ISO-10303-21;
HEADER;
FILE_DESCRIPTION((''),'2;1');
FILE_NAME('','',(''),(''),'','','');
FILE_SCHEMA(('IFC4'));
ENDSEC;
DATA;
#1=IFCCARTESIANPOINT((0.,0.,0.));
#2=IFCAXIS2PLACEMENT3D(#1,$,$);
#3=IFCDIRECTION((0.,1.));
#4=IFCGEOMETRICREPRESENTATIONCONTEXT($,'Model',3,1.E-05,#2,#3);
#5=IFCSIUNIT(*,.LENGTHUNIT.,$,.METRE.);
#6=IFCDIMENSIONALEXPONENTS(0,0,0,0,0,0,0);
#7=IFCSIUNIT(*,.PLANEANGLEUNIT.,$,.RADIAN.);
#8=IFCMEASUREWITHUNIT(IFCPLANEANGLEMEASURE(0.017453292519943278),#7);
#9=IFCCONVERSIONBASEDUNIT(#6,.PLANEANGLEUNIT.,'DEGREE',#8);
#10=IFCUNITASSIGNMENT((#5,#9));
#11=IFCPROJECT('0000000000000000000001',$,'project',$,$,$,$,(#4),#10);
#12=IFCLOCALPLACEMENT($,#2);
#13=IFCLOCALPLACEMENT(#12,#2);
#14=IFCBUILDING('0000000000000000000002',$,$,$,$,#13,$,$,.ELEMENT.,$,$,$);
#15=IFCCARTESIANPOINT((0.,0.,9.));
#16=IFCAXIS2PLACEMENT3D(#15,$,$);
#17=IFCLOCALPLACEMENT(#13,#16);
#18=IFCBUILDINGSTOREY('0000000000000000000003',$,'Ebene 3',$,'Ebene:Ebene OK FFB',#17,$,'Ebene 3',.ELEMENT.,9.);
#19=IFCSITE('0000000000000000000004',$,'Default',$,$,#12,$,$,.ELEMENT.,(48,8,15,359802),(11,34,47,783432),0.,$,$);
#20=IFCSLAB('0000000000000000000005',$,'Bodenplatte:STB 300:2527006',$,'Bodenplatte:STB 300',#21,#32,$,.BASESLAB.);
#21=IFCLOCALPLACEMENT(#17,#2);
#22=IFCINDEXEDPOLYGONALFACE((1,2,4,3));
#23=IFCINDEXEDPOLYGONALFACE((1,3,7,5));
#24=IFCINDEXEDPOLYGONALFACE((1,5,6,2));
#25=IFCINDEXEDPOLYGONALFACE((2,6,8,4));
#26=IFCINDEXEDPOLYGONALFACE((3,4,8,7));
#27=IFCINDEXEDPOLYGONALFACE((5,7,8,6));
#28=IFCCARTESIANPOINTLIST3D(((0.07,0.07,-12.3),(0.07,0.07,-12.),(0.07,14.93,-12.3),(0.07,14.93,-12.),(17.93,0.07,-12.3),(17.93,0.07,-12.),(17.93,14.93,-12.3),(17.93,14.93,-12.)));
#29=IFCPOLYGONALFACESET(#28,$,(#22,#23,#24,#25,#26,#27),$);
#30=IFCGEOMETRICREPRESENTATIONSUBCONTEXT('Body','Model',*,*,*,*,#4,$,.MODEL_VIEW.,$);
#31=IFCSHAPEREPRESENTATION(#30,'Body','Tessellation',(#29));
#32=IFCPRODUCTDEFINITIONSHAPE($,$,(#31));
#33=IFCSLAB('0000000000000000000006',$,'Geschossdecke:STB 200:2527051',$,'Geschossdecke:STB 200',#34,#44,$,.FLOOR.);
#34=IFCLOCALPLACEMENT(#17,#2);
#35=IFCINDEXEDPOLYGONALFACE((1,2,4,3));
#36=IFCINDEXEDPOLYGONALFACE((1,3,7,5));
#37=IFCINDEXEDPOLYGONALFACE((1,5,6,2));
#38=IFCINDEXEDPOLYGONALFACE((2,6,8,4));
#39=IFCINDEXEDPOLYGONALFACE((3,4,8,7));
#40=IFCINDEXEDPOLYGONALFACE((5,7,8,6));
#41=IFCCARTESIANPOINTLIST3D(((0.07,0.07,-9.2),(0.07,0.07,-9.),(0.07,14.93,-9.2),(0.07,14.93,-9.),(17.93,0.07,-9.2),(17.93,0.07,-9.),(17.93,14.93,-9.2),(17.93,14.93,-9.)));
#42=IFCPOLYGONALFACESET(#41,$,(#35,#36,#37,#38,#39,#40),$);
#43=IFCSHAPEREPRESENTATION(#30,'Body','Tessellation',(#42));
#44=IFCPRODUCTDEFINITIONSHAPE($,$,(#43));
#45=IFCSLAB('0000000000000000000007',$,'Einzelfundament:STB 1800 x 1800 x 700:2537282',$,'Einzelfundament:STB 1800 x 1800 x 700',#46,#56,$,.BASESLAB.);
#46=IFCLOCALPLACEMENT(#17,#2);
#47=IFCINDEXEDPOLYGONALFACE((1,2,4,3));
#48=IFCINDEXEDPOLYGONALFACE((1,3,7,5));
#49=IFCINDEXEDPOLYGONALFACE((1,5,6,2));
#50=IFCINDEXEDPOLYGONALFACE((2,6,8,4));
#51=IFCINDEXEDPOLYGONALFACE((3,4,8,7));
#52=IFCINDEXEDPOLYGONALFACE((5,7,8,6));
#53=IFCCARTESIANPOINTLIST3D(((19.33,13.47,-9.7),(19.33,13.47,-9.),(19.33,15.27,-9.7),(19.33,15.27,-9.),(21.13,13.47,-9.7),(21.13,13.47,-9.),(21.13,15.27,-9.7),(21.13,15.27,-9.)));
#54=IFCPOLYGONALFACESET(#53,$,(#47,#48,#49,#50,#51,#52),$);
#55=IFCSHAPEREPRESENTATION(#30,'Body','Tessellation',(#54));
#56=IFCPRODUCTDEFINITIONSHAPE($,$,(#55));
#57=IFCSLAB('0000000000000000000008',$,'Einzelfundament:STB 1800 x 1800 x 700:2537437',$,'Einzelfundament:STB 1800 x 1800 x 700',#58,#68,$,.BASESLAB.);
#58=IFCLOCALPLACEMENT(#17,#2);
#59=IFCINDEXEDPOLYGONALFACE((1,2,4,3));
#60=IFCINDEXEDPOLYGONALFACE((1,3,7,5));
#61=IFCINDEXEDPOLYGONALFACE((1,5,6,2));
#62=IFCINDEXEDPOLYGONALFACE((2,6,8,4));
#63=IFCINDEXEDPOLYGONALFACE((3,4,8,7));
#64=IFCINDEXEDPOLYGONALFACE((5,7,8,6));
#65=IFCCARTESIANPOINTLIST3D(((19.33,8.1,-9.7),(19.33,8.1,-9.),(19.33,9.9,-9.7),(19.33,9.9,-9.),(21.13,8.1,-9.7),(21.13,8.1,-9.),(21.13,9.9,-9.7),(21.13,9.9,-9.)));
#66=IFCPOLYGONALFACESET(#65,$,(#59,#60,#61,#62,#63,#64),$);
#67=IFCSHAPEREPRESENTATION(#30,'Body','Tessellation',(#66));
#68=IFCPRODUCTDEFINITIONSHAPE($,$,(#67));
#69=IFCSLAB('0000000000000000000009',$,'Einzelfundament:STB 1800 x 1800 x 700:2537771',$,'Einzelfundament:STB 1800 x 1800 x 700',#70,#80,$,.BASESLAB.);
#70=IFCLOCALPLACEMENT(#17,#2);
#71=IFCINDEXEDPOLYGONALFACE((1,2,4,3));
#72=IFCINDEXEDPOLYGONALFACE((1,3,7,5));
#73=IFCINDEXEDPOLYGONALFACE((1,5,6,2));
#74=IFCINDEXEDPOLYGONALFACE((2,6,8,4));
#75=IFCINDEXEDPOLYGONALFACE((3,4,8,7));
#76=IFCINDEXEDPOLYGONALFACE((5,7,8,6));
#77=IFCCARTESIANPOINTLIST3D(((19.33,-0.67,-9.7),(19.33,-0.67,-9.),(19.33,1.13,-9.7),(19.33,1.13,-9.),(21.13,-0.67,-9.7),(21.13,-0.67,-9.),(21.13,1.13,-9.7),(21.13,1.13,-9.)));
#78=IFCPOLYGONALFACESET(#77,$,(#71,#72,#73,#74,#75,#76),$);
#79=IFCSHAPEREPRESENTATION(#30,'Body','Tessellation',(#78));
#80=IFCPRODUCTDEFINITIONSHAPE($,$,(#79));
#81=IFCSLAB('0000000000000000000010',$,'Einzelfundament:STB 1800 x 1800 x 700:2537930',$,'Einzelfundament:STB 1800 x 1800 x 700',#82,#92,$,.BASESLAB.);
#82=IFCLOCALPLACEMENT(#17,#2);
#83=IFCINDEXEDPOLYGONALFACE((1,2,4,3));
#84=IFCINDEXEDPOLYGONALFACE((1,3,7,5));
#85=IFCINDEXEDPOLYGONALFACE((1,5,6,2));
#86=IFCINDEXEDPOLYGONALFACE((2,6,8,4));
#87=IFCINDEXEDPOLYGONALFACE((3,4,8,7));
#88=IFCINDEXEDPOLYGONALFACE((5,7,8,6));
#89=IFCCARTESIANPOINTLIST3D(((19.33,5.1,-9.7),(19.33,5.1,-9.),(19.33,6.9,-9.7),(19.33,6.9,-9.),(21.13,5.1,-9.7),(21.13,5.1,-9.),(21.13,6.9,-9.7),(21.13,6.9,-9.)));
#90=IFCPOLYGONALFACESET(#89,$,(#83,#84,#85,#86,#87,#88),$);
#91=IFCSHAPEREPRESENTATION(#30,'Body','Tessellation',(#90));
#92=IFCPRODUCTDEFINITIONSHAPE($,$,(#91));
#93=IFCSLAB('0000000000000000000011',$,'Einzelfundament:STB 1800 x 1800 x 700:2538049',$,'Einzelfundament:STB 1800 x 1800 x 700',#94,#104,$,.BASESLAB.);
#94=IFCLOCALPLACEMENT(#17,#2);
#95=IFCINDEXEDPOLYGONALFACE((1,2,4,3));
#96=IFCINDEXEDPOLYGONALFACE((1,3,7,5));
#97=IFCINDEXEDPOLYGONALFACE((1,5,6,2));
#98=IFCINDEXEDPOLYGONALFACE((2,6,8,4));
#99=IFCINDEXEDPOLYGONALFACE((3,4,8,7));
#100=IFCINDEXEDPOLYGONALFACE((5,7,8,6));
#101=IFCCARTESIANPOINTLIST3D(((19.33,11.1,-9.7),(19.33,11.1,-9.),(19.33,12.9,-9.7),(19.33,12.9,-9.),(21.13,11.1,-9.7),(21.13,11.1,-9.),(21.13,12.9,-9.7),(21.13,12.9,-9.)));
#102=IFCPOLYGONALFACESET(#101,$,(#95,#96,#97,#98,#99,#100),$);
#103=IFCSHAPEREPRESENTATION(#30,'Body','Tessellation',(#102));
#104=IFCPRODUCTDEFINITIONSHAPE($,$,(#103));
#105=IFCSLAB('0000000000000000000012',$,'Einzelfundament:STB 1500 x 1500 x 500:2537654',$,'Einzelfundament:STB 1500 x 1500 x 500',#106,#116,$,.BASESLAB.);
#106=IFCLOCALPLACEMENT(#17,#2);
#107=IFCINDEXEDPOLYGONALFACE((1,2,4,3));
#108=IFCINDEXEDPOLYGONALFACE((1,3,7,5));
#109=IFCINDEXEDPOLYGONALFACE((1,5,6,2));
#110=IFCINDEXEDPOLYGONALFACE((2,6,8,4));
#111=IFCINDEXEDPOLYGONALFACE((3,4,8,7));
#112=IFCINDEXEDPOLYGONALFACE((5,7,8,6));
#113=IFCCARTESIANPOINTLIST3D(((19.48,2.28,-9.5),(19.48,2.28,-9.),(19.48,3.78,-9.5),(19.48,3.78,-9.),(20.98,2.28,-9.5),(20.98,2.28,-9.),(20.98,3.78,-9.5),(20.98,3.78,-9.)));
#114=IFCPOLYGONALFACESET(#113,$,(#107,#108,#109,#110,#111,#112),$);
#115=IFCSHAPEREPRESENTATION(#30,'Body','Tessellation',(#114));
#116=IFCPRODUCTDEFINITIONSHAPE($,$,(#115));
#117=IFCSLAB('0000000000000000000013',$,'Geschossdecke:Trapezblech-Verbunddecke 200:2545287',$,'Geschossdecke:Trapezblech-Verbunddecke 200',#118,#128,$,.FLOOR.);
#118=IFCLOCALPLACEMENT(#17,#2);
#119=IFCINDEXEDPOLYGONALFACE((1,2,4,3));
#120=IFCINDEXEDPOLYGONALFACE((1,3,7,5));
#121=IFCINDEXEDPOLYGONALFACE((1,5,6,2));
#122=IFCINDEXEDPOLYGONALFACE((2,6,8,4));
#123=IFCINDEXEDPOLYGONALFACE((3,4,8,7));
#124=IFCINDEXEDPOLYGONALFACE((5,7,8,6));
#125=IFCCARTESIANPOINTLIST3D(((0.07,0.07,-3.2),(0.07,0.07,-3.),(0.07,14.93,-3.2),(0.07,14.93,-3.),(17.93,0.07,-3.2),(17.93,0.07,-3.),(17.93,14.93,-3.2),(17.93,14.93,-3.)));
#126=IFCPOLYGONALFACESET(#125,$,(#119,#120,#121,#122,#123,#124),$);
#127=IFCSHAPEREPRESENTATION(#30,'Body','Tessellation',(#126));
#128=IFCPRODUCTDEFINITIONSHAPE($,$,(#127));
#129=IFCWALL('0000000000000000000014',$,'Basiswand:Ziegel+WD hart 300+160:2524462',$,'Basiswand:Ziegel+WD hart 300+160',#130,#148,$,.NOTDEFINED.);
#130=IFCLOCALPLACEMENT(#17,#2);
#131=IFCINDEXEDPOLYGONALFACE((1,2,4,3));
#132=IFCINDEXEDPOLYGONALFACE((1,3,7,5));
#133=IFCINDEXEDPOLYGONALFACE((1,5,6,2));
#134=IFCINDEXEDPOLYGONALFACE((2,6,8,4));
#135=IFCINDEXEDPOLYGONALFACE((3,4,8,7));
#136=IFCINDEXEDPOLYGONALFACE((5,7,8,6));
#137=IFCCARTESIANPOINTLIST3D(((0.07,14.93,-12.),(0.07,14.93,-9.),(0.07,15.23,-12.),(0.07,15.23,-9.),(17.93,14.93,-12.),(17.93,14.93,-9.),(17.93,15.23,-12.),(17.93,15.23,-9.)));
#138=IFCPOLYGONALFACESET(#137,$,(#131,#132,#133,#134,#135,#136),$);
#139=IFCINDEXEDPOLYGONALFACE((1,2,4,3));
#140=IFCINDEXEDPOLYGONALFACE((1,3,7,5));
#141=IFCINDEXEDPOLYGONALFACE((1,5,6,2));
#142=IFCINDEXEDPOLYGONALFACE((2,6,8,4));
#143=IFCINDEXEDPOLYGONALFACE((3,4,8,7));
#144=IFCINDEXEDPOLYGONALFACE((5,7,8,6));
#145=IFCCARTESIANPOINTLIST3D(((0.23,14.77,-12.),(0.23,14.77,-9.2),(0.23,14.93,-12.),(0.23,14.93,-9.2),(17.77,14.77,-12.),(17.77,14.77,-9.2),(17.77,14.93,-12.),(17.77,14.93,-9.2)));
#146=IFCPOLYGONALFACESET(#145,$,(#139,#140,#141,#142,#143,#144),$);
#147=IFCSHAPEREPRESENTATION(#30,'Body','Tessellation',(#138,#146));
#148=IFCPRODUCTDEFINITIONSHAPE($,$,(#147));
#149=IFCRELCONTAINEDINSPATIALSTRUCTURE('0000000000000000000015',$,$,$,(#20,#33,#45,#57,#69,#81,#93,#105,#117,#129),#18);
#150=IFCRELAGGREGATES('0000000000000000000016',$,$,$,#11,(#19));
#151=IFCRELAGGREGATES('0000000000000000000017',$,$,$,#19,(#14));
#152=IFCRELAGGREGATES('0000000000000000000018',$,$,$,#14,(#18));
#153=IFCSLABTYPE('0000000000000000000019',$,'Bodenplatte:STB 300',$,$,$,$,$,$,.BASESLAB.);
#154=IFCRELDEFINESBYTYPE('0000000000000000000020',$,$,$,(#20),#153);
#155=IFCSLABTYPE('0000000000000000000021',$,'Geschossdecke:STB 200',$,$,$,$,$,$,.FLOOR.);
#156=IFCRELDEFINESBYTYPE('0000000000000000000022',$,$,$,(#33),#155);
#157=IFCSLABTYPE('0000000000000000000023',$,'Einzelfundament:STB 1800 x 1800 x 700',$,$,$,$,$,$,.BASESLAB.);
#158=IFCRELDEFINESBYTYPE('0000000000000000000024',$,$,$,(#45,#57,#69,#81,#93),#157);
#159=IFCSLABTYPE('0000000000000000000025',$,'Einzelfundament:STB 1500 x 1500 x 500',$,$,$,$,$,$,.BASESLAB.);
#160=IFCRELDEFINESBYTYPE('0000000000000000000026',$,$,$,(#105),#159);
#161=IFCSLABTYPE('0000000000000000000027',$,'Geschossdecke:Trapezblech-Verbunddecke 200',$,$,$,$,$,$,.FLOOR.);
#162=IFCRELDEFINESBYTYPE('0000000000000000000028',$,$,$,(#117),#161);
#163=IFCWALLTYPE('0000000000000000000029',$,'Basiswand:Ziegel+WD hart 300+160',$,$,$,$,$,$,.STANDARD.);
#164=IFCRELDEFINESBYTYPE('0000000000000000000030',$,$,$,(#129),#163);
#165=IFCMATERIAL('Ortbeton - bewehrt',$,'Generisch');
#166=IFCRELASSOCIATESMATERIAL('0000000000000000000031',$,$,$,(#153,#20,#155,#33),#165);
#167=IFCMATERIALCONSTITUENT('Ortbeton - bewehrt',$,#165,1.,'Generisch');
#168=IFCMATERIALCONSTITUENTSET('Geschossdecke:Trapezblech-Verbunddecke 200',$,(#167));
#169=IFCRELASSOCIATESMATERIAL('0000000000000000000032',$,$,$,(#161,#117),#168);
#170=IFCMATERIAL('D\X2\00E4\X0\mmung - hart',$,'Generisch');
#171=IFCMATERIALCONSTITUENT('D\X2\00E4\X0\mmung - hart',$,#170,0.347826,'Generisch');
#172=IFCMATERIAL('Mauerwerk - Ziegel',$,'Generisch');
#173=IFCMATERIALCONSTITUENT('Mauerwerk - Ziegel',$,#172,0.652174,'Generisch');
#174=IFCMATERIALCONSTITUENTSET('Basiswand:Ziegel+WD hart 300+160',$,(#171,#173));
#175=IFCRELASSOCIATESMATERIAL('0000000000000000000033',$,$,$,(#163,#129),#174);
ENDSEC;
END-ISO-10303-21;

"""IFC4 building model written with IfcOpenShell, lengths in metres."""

from ifc_helpers import new_model, entity, si_unit, converted_unit, direction, frame, origin, place, context, subcontext, project, spatial, indexed_curve, outline, extrude, material, constituent, constituent_set, type_object, element, save


model = new_model("IFC4")

# Units and contexts
model_context = context("Model", 3, precision=1e-05, world=origin(), true_north=direction((0.0, 1.0)))
body_context = subcontext(model_context, "Body", "Model", "MODEL_VIEW")
ifc_project = project(units=[si_unit("LENGTHUNIT", "METRE"), converted_unit("PLANEANGLEUNIT", "DEGREE", entity("IfcPlaneAngleMeasure", 0.017453292519943278), si_unit("PLANEANGLEUNIT", "RADIAN"), dimensions=[0, 0, 0, 0, 0, 0, 0])], contexts=[model_context])

# Site, building, storey
site_placement = place(None, origin())
site = spatial("IfcSite", under=ifc_project, at=site_placement, Name="Default", CompositionType="ELEMENT", RefLatitude=(48, 8, 15, 359802), RefLongitude=(11, 34, 47, 783432), RefElevation=0.0)
building_placement = place(site_placement, origin())
building = spatial("IfcBuilding", under=site, at=building_placement, CompositionType="ELEMENT")
storey_placement = place(building_placement, frame((0.0, 0.0, 9.0)))
storey = spatial("IfcBuildingStorey", under=building, at=storey_placement, Name="Ebene 3", ObjectType="Ebene:Ebene OK FFB", LongName="Ebene 3", CompositionType="ELEMENT", Elevation=9.0)

# Slabs
ifc_material_1 = material(Name="Ortbeton - bewehrt", Category="Generisch")
slab_type_1 = type_object("IfcSlabType", Name="Bodenplatte:STB 300", PredefinedType="BASESLAB", material=ifc_material_1)
slab_1_placement = place(storey_placement, origin())
element("IfcSlab", 1, at=slab_1_placement, inside=storey, type_object=slab_type_1, material=ifc_material_1, Name="Bodenplatte:STB 300:2527006", ObjectType="Bodenplatte:STB 300", PredefinedType="BASESLAB", context=body_context, shape_type="SweptSolid", body=[
    extrude(outline(indexed_curve([(-7.43, -8.93), (7.43, -8.93), (7.43, 8.93), (-7.43, 8.93), (-7.43, -8.93)], self_intersect=False)), frame((9.0, 7.5, -12.0), z_axis=(0.0, 0.0, -1.0), x_axis=(0.0, 1.0, 0.0)), (0.0, 0.0, 1.0), 0.3),
])
slab_type_2 = type_object("IfcSlabType", Name="Geschossdecke:STB 200", PredefinedType="FLOOR", material=ifc_material_1)
slab_2_placement = place(storey_placement, origin())
element("IfcSlab", 2, at=slab_2_placement, inside=storey, type_object=slab_type_2, material=ifc_material_1, Name="Geschossdecke:STB 200:2527051", ObjectType="Geschossdecke:STB 200", PredefinedType="FLOOR", context=body_context, shape_type="SweptSolid", body=[
    extrude(outline(indexed_curve([(-7.43, -8.93), (7.43, -8.93), (7.43, 8.93), (-7.43, 8.93), (-7.43, -8.93)], self_intersect=False)), frame((9.0, 7.5, -9.0), z_axis=(0.0, 0.0, -1.0), x_axis=(0.0, 1.0, 0.0)), (0.0, 0.0, 1.0), 0.2),
])

# Slabs
slab_type_3 = type_object("IfcSlabType", Name="Einzelfundament:STB 1800 x 1800 x 700", PredefinedType="BASESLAB")
slab_3_placement = place(storey_placement, origin())
element("IfcSlab", 3, at=slab_3_placement, inside=storey, type_object=slab_type_3, Name="Einzelfundament:STB 1800 x 1800 x 700:2537282", ObjectType="Einzelfundament:STB 1800 x 1800 x 700", PredefinedType="BASESLAB", context=body_context, shape_type="SweptSolid", body=[
    extrude(outline(indexed_curve([(-0.9, -0.9), (0.9, -0.9), (0.9, 0.9), (-0.9, 0.9), (-0.9, -0.9)], self_intersect=False)), frame((20.23, 14.37, -9.7), z_axis=(0.0, 0.0, 1.0), x_axis=(-1.0, 0.0, 0.0)), (0.0, 0.0, 1.0), 0.7),
])
slab_4_placement = place(storey_placement, origin())
element("IfcSlab", 4, at=slab_4_placement, inside=storey, type_object=slab_type_3, Name="Einzelfundament:STB 1800 x 1800 x 700:2537437", ObjectType="Einzelfundament:STB 1800 x 1800 x 700", PredefinedType="BASESLAB", context=body_context, shape_type="SweptSolid", body=[
    extrude(outline(indexed_curve([(-0.9, -0.9), (0.9, -0.9), (0.9, 0.9), (-0.9, 0.9), (-0.9, -0.9)], self_intersect=False)), frame((20.23, 9.0, -9.7), z_axis=(0.0, 0.0, 1.0), x_axis=(-1.0, 0.0, 0.0)), (0.0, 0.0, 1.0), 0.7),
])
slab_5_placement = place(storey_placement, origin())
element("IfcSlab", 5, at=slab_5_placement, inside=storey, type_object=slab_type_3, Name="Einzelfundament:STB 1800 x 1800 x 700:2537771", ObjectType="Einzelfundament:STB 1800 x 1800 x 700", PredefinedType="BASESLAB", context=body_context, shape_type="SweptSolid", body=[
    extrude(outline(indexed_curve([(-0.9, -0.9), (0.9, -0.9), (0.9, 0.9), (-0.9, 0.9), (-0.9, -0.9)], self_intersect=False)), frame((20.23, 0.23, -9.7), z_axis=(0.0, 0.0, 1.0), x_axis=(-1.0, 0.0, 0.0)), (0.0, 0.0, 1.0), 0.7),
])
slab_6_placement = place(storey_placement, origin())
element("IfcSlab", 6, at=slab_6_placement, inside=storey, type_object=slab_type_3, Name="Einzelfundament:STB 1800 x 1800 x 700:2537930", ObjectType="Einzelfundament:STB 1800 x 1800 x 700", PredefinedType="BASESLAB", context=body_context, shape_type="SweptSolid", body=[
    extrude(outline(indexed_curve([(-0.9, -0.9), (0.9, -0.9), (0.9, 0.9), (-0.9, 0.9), (-0.9, -0.9)], self_intersect=False)), frame((20.23, 6.0, -9.7), z_axis=(0.0, 0.0, 1.0), x_axis=(-1.0, 0.0, 0.0)), (0.0, 0.0, 1.0), 0.7),
])
slab_7_placement = place(storey_placement, origin())
element("IfcSlab", 7, at=slab_7_placement, inside=storey, type_object=slab_type_3, Name="Einzelfundament:STB 1800 x 1800 x 700:2538049", ObjectType="Einzelfundament:STB 1800 x 1800 x 700", PredefinedType="BASESLAB", context=body_context, shape_type="SweptSolid", body=[
    extrude(outline(indexed_curve([(-0.9, -0.9), (0.9, -0.9), (0.9, 0.9), (-0.9, 0.9), (-0.9, -0.9)], self_intersect=False)), frame((20.23, 12.0, -9.7), z_axis=(0.0, 0.0, 1.0), x_axis=(-1.0, 0.0, 0.0)), (0.0, 0.0, 1.0), 0.7),
])
slab_type_4 = type_object("IfcSlabType", Name="Einzelfundament:STB 1500 x 1500 x 500", PredefinedType="BASESLAB")
slab_8_placement = place(storey_placement, origin())
element("IfcSlab", 8, at=slab_8_placement, inside=storey, type_object=slab_type_4, Name="Einzelfundament:STB 1500 x 1500 x 500:2537654", ObjectType="Einzelfundament:STB 1500 x 1500 x 500", PredefinedType="BASESLAB", context=body_context, shape_type="SweptSolid", body=[
    extrude(outline(indexed_curve([(-0.75, -0.75), (0.75, -0.75), (0.75, 0.75), (-0.75, 0.75), (-0.75, -0.75)], self_intersect=False)), frame((20.23, 3.03, -9.5), z_axis=(0.0, 0.0, 1.0), x_axis=(-1.0, 0.0, 0.0)), (0.0, 0.0, 1.0), 0.5),
])
ifc_constituent_1 = constituent(ifc_material_1, Name="Ortbeton - bewehrt", Category="Generisch", fraction=1.0)
ifc_constituent_set_1 = constituent_set(constituents=[ifc_constituent_1], Name="Geschossdecke:Trapezblech-Verbunddecke 200")
slab_type_5 = type_object("IfcSlabType", Name="Geschossdecke:Trapezblech-Verbunddecke 200", PredefinedType="FLOOR", material=ifc_constituent_set_1)
slab_9_placement = place(storey_placement, origin())
element("IfcSlab", 9, at=slab_9_placement, inside=storey, type_object=slab_type_5, material=ifc_constituent_set_1, Name="Geschossdecke:Trapezblech-Verbunddecke 200:2545287", ObjectType="Geschossdecke:Trapezblech-Verbunddecke 200", PredefinedType="FLOOR", context=body_context, shape_type="SweptSolid", body=[
    extrude(outline(indexed_curve([(-7.43, -8.93), (7.43, -8.93), (7.43, 8.93), (-7.43, 8.93), (-7.43, -8.93)], self_intersect=False)), frame((9.0, 7.5, -3.0), z_axis=(0.0, 0.0, -1.0), x_axis=(0.0, 1.0, 0.0)), (0.0, 0.0, 1.0), 0.2),
])

# Wall
ifc_material_2 = material(Name="Dämmung - hart", Category="Generisch")
ifc_constituent_2 = constituent(ifc_material_2, Name="Dämmung - hart", Category="Generisch", fraction=0.347826)
ifc_material_3 = material(Name="Mauerwerk - Ziegel", Category="Generisch")
ifc_constituent_3 = constituent(ifc_material_3, Name="Mauerwerk - Ziegel", Category="Generisch", fraction=0.652174)
ifc_constituent_set_2 = constituent_set(constituents=[ifc_constituent_2, ifc_constituent_3], Name="Basiswand:Ziegel+WD hart 300+160")
wall_type = type_object("IfcWallType", Name="Basiswand:Ziegel+WD hart 300+160", PredefinedType="STANDARD", material=ifc_constituent_set_2)
wall_1_placement = place(storey_placement, frame((17.77, 15.0, -12.0), z_axis=(0.0, 0.0, 1.0), x_axis=(-1.0, 0.0, 0.0)))
element("IfcWall", 10, at=wall_1_placement, inside=storey, type_object=wall_type, material=ifc_constituent_set_2, Name="Basiswand:Ziegel+WD hart 300+160:2524462", ObjectType="Basiswand:Ziegel+WD hart 300+160", PredefinedType="NOTDEFINED", context=body_context, shape_type="SweptSolid", body=[
    extrude(outline(indexed_curve([(-0.15, -8.93), (0.15, -8.93), (0.15, 8.93), (-0.15, 8.93), (-0.15, -8.93)], self_intersect=False)), frame((8.77, -0.08, 0.0), z_axis=(0.0, 0.0, 1.0), x_axis=(0.0, 1.0, 0.0)), (0.0, 0.0, 1.0), 3.0),
    extrude(outline(indexed_curve([(-0.08, -8.77), (0.08, -8.77), (0.08, 8.77), (-0.08, 8.77), (-0.08, -8.77)], self_intersect=False)), frame((8.77, 0.15, 0.0), z_axis=(0.0, 0.0, 1.0), x_axis=(0.0, -1.0, 0.0)), (0.0, 0.0, 1.0), 2.8),
])

save(model, "model.ifc")
